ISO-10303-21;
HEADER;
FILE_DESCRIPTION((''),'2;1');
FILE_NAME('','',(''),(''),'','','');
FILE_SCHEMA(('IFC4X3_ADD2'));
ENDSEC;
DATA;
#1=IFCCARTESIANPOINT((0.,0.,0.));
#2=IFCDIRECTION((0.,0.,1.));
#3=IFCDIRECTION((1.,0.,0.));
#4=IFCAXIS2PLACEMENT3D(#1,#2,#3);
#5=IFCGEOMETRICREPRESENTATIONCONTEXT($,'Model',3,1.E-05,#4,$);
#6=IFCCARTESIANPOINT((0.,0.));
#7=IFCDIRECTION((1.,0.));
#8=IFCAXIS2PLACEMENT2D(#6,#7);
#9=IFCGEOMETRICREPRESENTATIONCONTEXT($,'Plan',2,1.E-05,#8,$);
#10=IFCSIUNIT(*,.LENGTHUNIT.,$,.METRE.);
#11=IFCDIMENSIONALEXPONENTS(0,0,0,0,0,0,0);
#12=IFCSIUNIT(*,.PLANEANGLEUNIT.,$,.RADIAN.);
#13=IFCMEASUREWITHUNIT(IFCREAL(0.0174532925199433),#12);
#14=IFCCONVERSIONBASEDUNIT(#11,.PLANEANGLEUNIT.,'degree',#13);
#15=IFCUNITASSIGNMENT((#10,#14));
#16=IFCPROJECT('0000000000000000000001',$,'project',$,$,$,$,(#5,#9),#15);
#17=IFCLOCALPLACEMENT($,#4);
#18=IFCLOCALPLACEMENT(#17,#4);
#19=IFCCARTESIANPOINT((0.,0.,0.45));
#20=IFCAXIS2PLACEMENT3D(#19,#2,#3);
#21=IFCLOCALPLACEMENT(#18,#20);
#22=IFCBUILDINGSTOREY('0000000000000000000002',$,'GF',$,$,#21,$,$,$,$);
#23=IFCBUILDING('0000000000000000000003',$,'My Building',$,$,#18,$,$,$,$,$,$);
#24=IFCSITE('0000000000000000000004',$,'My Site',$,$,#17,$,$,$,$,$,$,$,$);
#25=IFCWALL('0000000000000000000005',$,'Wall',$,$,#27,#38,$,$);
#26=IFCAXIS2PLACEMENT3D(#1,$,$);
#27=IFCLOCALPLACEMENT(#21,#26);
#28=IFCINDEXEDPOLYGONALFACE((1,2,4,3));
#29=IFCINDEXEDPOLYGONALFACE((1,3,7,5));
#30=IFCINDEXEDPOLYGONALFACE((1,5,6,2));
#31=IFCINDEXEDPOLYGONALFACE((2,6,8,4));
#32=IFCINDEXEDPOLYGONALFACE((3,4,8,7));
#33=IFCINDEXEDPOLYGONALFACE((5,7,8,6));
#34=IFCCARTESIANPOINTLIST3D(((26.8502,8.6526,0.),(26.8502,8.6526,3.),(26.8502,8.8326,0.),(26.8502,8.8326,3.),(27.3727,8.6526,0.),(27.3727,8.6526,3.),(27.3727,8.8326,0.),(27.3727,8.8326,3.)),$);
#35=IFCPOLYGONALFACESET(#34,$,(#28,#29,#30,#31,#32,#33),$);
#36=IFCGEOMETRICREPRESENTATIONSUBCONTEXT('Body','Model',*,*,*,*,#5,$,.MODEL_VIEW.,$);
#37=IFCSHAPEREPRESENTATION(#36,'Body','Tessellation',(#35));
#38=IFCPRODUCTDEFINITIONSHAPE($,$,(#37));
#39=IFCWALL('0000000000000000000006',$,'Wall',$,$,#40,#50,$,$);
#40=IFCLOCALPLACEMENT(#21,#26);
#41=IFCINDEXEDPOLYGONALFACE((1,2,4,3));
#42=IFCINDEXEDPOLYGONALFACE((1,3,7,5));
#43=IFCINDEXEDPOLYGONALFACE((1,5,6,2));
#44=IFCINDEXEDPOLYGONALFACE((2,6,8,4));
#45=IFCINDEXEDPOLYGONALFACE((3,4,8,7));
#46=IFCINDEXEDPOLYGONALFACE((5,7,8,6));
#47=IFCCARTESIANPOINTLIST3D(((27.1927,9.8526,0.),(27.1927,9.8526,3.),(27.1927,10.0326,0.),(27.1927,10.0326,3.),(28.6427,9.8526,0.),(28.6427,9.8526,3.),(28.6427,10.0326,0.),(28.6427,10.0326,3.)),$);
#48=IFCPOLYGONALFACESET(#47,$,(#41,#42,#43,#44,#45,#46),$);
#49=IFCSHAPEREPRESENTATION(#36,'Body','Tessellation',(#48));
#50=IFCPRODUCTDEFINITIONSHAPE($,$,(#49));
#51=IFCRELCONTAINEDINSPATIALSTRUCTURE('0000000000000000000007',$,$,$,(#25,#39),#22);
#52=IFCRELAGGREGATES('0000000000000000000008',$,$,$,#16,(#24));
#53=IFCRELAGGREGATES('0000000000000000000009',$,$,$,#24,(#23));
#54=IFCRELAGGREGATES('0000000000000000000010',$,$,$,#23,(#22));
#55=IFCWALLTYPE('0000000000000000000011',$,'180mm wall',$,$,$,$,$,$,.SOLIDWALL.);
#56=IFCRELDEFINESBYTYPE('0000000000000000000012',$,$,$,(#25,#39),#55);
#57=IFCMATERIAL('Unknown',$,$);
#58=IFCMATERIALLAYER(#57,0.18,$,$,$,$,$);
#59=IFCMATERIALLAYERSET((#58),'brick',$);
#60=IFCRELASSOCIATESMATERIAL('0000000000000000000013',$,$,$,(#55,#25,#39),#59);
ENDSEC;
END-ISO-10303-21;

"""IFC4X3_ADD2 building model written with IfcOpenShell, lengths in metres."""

from ifc_helpers import new_model, entity, si_unit, converted_unit, frame, origin_with_axes, origin_2d_with_axis, place, context, subcontext, project, spatial, indexed_curve, outline, extrude, material, layer, layer_set, layer_usage, type_object, element, save


model = new_model("IFC4X3_ADD2")

# Units and contexts
model_context = context("Model", 3, precision=1e-05, world=origin_with_axes())
plan_context = context("Plan", 2, precision=1e-05, world=origin_2d_with_axis())
body_context = subcontext(model_context, "Body", "Model", "MODEL_VIEW")
ifc_project = project(units=[si_unit("LENGTHUNIT", "METRE"), converted_unit("PLANEANGLEUNIT", "degree", entity("IfcReal", 0.0174532925199433), si_unit("PLANEANGLEUNIT", "RADIAN"), dimensions=[0, 0, 0, 0, 0, 0, 0])], contexts=[model_context, plan_context])

# Site, building, storey
site_placement = place(None, origin_with_axes())
site = spatial("IfcSite", under=ifc_project, at=site_placement, Name="My Site")
building_placement = place(site_placement, origin_with_axes())
building = spatial("IfcBuilding", under=site, at=building_placement, Name="My Building")
storey_placement = place(building_placement, frame((0.0, 0.0, 0.45), z_axis=(0.0, 0.0, 1.0), x_axis=(1.0, 0.0, 0.0)))
storey = spatial("IfcBuildingStorey", under=building, at=storey_placement, Name="GF")

# Walls
ifc_material_1 = material(Name="Unknown")
ifc_layer = layer(ifc_material_1, 0.18)
ifc_layer_set = layer_set([ifc_layer], Name="brick")
wall_type = type_object("IfcWallType", Name="180mm wall", PredefinedType="SOLIDWALL", material=ifc_layer_set)
ifc_layer_usage_1 = layer_usage(ifc_layer_set, "AXIS2", "POSITIVE", 0.0)
wall_1_placement = place(storey_placement, frame((27.3727, 8.8326, 0.0), z_axis=(0.0, 0.0, 1.0), x_axis=(-1.0, 0.0, 0.0)))
element("IfcWall", 1, at=wall_1_placement, inside=storey, type_object=wall_type, material=ifc_layer_usage_1, Name="Wall", context=body_context, shape_type="SweptSolid", body=[
    extrude(outline(indexed_curve([(0.0, 0.0), (0.0, 0.18), (0.5225, 0.18), (0.5225, 0.0), (0.0, 0.0)], self_intersect=False)), origin_with_axes(), (0.0, 0.0, 1.0), 3.0),
])
ifc_layer_usage_2 = layer_usage(ifc_layer_set, "AXIS2", "POSITIVE", 0.0)
wall_2_placement = place(storey_placement, frame((28.6427, 10.0326, 0.0), z_axis=(0.0, 0.0, 1.0), x_axis=(-1.0, 0.0, 0.0)))
element("IfcWall", 2, at=wall_2_placement, inside=storey, type_object=wall_type, material=ifc_layer_usage_2, Name="Wall", context=body_context, shape_type="SweptSolid", body=[
    extrude(outline(indexed_curve([(0.0, 0.0), (0.0, 0.18), (1.45, 0.18), (1.45, 0.0), (0.0, 0.0)], self_intersect=False)), origin_with_axes(), (0.0, 0.0, 1.0), 3.0),
])

save(model, "model.ifc")
